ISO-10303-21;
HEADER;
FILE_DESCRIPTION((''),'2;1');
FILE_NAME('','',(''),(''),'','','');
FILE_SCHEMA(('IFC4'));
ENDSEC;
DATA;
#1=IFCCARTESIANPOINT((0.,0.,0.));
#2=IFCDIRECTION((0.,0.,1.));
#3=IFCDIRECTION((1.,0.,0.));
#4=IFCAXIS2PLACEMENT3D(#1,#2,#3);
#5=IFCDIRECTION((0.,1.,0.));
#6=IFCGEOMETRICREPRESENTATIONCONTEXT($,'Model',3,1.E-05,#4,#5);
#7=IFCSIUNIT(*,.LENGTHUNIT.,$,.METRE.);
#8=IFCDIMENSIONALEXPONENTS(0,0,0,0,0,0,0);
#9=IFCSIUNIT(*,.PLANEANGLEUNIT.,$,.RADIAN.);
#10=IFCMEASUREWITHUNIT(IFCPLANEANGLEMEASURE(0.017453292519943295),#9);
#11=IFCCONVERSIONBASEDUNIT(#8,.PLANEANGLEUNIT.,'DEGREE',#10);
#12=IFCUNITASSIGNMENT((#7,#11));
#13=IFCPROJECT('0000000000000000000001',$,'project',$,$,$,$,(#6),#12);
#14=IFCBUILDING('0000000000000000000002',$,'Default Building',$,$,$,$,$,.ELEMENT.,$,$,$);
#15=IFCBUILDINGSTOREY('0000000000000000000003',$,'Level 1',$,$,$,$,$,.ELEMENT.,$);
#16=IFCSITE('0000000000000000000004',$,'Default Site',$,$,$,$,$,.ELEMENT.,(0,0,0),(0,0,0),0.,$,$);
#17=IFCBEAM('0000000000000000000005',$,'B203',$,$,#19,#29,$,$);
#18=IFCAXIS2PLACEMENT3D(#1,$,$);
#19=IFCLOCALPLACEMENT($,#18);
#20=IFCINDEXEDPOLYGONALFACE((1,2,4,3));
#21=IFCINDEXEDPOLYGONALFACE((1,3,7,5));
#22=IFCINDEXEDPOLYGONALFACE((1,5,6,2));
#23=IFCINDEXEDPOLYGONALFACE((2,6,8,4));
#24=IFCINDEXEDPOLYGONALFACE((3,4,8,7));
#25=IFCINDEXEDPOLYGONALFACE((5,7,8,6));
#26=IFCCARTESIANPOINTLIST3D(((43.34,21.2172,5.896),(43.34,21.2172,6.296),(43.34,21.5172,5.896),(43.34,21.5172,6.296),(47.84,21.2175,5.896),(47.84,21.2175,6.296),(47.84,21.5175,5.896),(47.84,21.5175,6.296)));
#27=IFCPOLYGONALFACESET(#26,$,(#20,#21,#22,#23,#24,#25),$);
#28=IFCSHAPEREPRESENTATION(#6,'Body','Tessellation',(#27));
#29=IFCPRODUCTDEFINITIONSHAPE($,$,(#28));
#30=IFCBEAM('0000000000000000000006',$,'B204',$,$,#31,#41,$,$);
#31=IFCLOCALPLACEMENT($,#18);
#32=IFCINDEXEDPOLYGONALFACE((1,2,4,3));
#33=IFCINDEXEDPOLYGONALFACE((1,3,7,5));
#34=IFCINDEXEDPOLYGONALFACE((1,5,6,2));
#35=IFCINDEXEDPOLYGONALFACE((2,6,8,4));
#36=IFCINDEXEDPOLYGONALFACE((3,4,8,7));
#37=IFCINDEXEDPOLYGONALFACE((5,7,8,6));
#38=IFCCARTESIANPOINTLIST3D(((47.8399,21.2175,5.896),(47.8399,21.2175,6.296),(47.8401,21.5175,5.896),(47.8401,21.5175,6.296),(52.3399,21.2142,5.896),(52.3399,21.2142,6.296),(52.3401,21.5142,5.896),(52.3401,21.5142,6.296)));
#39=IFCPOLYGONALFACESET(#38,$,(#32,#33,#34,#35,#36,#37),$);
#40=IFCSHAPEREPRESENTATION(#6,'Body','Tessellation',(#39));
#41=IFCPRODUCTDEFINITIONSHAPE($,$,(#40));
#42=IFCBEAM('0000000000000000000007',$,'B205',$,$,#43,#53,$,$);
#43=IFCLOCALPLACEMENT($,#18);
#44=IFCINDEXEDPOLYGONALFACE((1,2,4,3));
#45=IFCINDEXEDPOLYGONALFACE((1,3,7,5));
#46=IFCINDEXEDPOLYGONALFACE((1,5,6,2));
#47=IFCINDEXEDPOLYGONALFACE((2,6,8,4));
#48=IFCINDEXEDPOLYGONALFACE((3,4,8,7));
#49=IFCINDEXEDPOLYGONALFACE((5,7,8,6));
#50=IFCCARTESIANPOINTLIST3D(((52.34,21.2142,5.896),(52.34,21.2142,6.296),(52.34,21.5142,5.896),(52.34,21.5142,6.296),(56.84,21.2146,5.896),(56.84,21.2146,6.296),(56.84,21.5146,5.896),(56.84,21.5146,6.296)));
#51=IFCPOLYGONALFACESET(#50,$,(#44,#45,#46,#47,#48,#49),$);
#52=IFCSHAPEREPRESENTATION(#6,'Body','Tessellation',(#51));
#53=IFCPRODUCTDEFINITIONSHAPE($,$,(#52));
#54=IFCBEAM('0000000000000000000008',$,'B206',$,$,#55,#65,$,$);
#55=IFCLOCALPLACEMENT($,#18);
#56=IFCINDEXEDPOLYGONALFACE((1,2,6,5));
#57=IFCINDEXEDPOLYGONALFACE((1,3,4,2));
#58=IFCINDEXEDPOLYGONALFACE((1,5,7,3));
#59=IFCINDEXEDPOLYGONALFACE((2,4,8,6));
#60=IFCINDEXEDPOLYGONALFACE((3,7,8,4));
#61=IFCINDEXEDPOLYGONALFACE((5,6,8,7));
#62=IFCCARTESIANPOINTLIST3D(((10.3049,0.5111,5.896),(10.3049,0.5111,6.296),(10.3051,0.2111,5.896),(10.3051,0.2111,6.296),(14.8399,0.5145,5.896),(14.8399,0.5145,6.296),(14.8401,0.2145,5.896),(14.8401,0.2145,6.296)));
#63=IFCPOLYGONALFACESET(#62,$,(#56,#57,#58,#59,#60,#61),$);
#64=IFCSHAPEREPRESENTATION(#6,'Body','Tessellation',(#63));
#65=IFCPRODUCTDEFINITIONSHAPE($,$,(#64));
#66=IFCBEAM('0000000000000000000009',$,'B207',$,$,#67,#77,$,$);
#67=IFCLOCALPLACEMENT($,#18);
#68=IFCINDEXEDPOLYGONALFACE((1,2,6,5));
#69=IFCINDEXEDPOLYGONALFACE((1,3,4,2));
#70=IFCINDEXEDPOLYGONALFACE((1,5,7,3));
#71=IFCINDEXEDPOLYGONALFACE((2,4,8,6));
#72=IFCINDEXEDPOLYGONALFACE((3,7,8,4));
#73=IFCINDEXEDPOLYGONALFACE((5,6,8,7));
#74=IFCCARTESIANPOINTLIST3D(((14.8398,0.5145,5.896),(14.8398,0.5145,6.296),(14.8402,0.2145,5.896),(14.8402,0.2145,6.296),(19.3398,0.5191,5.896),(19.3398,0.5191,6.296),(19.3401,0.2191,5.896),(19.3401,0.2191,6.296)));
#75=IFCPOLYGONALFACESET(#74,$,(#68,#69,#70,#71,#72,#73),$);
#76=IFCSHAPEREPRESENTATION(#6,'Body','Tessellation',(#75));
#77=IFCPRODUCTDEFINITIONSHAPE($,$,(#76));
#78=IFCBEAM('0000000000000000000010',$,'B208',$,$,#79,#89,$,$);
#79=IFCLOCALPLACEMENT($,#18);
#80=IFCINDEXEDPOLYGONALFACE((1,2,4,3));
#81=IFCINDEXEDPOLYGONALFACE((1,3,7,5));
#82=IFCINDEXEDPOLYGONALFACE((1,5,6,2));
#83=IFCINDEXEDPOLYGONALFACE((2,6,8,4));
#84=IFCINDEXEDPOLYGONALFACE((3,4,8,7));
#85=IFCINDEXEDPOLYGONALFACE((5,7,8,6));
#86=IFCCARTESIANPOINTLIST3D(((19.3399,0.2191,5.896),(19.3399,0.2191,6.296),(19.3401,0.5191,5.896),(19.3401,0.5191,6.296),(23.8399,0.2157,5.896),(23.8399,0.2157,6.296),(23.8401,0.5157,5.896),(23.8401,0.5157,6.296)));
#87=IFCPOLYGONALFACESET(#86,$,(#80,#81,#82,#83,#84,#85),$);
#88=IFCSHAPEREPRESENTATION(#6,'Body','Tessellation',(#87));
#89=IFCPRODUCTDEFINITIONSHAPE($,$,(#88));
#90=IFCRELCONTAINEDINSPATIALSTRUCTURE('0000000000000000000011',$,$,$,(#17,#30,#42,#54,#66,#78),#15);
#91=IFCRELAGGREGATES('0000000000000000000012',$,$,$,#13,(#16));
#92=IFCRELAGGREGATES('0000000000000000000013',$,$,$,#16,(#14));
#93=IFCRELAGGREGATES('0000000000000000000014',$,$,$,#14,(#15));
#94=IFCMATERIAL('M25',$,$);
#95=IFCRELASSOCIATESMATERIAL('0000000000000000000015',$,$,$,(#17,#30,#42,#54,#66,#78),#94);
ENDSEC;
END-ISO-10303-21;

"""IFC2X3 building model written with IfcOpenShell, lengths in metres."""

from ifc_helpers import new_model, entity, si_unit, converted_unit, direction, frame, frame_2d, origin_with_axes, place, context, project, spatial, rectangle, extrude, material, element, save


model = new_model("IFC2X3")

# Units and contexts
model_context = context("Model", 3, precision=1e-05, world=origin_with_axes(), true_north=direction((0.0, 1.0, 0.0)))
ifc_project = project(units=[si_unit("LENGTHUNIT", "METRE"), converted_unit("PLANEANGLEUNIT", "DEGREE", entity("IfcPlaneAngleMeasure", 0.017453292519943295), si_unit("PLANEANGLEUNIT", "RADIAN"), dimensions=[0, 0, 0, 0, 0, 0, 0])], contexts=[model_context])

# Site, building, storey
site = spatial("IfcSite", under=ifc_project, Name="Default Site", CompositionType="ELEMENT", RefLatitude=(0, 0, 0), RefLongitude=(0, 0, 0), RefElevation=0.0)
building = spatial("IfcBuilding", under=site, Name="Default Building", CompositionType="ELEMENT")
storey = spatial("IfcBuildingStorey", under=building, Name="Level 1", CompositionType="ELEMENT")

# Shared definitions
ifc_material = material(Name="M25")
placement = place(None, origin_with_axes())

# Beams
element("IfcBeam", 1, at=placement, inside=storey, material=ifc_material, Name="B203", context=model_context, shape_type="SweptSolid", body=[
    extrude(rectangle(XDim=0.3, YDim=0.4, at=frame_2d((0.0, 0.0), x_axis=(0.0, 1.0, 0.0))), frame((43.34, 21.3672, 6.096), z_axis=(1.0, 0.000075, 0.0), x_axis=(0.0, 0.0, -1.0)), (0.0, 0.0, 1.0), 4.5),
])
element("IfcBeam", 2, at=placement, inside=storey, material=ifc_material, Name="B204", context=model_context, shape_type="SweptSolid", body=[
    extrude(rectangle(XDim=0.3, YDim=0.4, at=frame_2d((0.0, 0.0), x_axis=(0.0, 1.0, 0.0))), frame((47.84, 21.3675, 6.096), z_axis=(1.0, -0.000744, 0.0), x_axis=(0.0, 0.0, -1.0)), (0.0, 0.0, 1.0), 4.5),
])
element("IfcBeam", 3, at=placement, inside=storey, material=ifc_material, Name="B205", context=model_context, shape_type="SweptSolid", body=[
    extrude(rectangle(XDim=0.3, YDim=0.4, at=frame_2d((0.0, 0.0), x_axis=(0.0, 1.0, 0.0))), frame((52.34, 21.3642, 6.096), z_axis=(1.0, 0.000102, 0.0), x_axis=(0.0, 0.0, -1.0)), (0.0, 0.0, 1.0), 4.5),
])
element("IfcBeam", 4, at=placement, inside=storey, material=ifc_material, Name="B206", context=model_context, shape_type="SweptSolid", body=[
    extrude(rectangle(XDim=0.3, YDim=0.4, at=frame_2d((0.0, 0.0), x_axis=(0.0, 1.0, 0.0))), frame((10.305, 0.3611, 6.096), z_axis=(1.0, 0.000762, 0.0), x_axis=(0.0, 0.0, -1.0)), (0.0, 0.0, 1.0), 4.535),
])
element("IfcBeam", 5, at=placement, inside=storey, material=ifc_material, Name="B207", context=model_context, shape_type="SweptSolid", body=[
    extrude(rectangle(XDim=0.3, YDim=0.4, at=frame_2d((0.0, 0.0), x_axis=(0.0, 1.0, 0.0))), frame((14.84, 0.3645, 6.096), z_axis=(0.999999, 0.00101, 0.0), x_axis=(0.0, 0.0, -1.0)), (0.0, 0.0, 1.0), 4.5),
])
element("IfcBeam", 6, at=placement, inside=storey, material=ifc_material, Name="B208", context=model_context, shape_type="SweptSolid", body=[
    extrude(rectangle(XDim=0.3, YDim=0.4, at=frame_2d((0.0, 0.0), x_axis=(0.0, 1.0, 0.0))), frame((19.34, 0.3691, 6.096), z_axis=(1.0, -0.000757, 0.0), x_axis=(0.0, 0.0, -1.0)), (0.0, 0.0, 1.0), 4.5),
])

save(model, "model.ifc")
